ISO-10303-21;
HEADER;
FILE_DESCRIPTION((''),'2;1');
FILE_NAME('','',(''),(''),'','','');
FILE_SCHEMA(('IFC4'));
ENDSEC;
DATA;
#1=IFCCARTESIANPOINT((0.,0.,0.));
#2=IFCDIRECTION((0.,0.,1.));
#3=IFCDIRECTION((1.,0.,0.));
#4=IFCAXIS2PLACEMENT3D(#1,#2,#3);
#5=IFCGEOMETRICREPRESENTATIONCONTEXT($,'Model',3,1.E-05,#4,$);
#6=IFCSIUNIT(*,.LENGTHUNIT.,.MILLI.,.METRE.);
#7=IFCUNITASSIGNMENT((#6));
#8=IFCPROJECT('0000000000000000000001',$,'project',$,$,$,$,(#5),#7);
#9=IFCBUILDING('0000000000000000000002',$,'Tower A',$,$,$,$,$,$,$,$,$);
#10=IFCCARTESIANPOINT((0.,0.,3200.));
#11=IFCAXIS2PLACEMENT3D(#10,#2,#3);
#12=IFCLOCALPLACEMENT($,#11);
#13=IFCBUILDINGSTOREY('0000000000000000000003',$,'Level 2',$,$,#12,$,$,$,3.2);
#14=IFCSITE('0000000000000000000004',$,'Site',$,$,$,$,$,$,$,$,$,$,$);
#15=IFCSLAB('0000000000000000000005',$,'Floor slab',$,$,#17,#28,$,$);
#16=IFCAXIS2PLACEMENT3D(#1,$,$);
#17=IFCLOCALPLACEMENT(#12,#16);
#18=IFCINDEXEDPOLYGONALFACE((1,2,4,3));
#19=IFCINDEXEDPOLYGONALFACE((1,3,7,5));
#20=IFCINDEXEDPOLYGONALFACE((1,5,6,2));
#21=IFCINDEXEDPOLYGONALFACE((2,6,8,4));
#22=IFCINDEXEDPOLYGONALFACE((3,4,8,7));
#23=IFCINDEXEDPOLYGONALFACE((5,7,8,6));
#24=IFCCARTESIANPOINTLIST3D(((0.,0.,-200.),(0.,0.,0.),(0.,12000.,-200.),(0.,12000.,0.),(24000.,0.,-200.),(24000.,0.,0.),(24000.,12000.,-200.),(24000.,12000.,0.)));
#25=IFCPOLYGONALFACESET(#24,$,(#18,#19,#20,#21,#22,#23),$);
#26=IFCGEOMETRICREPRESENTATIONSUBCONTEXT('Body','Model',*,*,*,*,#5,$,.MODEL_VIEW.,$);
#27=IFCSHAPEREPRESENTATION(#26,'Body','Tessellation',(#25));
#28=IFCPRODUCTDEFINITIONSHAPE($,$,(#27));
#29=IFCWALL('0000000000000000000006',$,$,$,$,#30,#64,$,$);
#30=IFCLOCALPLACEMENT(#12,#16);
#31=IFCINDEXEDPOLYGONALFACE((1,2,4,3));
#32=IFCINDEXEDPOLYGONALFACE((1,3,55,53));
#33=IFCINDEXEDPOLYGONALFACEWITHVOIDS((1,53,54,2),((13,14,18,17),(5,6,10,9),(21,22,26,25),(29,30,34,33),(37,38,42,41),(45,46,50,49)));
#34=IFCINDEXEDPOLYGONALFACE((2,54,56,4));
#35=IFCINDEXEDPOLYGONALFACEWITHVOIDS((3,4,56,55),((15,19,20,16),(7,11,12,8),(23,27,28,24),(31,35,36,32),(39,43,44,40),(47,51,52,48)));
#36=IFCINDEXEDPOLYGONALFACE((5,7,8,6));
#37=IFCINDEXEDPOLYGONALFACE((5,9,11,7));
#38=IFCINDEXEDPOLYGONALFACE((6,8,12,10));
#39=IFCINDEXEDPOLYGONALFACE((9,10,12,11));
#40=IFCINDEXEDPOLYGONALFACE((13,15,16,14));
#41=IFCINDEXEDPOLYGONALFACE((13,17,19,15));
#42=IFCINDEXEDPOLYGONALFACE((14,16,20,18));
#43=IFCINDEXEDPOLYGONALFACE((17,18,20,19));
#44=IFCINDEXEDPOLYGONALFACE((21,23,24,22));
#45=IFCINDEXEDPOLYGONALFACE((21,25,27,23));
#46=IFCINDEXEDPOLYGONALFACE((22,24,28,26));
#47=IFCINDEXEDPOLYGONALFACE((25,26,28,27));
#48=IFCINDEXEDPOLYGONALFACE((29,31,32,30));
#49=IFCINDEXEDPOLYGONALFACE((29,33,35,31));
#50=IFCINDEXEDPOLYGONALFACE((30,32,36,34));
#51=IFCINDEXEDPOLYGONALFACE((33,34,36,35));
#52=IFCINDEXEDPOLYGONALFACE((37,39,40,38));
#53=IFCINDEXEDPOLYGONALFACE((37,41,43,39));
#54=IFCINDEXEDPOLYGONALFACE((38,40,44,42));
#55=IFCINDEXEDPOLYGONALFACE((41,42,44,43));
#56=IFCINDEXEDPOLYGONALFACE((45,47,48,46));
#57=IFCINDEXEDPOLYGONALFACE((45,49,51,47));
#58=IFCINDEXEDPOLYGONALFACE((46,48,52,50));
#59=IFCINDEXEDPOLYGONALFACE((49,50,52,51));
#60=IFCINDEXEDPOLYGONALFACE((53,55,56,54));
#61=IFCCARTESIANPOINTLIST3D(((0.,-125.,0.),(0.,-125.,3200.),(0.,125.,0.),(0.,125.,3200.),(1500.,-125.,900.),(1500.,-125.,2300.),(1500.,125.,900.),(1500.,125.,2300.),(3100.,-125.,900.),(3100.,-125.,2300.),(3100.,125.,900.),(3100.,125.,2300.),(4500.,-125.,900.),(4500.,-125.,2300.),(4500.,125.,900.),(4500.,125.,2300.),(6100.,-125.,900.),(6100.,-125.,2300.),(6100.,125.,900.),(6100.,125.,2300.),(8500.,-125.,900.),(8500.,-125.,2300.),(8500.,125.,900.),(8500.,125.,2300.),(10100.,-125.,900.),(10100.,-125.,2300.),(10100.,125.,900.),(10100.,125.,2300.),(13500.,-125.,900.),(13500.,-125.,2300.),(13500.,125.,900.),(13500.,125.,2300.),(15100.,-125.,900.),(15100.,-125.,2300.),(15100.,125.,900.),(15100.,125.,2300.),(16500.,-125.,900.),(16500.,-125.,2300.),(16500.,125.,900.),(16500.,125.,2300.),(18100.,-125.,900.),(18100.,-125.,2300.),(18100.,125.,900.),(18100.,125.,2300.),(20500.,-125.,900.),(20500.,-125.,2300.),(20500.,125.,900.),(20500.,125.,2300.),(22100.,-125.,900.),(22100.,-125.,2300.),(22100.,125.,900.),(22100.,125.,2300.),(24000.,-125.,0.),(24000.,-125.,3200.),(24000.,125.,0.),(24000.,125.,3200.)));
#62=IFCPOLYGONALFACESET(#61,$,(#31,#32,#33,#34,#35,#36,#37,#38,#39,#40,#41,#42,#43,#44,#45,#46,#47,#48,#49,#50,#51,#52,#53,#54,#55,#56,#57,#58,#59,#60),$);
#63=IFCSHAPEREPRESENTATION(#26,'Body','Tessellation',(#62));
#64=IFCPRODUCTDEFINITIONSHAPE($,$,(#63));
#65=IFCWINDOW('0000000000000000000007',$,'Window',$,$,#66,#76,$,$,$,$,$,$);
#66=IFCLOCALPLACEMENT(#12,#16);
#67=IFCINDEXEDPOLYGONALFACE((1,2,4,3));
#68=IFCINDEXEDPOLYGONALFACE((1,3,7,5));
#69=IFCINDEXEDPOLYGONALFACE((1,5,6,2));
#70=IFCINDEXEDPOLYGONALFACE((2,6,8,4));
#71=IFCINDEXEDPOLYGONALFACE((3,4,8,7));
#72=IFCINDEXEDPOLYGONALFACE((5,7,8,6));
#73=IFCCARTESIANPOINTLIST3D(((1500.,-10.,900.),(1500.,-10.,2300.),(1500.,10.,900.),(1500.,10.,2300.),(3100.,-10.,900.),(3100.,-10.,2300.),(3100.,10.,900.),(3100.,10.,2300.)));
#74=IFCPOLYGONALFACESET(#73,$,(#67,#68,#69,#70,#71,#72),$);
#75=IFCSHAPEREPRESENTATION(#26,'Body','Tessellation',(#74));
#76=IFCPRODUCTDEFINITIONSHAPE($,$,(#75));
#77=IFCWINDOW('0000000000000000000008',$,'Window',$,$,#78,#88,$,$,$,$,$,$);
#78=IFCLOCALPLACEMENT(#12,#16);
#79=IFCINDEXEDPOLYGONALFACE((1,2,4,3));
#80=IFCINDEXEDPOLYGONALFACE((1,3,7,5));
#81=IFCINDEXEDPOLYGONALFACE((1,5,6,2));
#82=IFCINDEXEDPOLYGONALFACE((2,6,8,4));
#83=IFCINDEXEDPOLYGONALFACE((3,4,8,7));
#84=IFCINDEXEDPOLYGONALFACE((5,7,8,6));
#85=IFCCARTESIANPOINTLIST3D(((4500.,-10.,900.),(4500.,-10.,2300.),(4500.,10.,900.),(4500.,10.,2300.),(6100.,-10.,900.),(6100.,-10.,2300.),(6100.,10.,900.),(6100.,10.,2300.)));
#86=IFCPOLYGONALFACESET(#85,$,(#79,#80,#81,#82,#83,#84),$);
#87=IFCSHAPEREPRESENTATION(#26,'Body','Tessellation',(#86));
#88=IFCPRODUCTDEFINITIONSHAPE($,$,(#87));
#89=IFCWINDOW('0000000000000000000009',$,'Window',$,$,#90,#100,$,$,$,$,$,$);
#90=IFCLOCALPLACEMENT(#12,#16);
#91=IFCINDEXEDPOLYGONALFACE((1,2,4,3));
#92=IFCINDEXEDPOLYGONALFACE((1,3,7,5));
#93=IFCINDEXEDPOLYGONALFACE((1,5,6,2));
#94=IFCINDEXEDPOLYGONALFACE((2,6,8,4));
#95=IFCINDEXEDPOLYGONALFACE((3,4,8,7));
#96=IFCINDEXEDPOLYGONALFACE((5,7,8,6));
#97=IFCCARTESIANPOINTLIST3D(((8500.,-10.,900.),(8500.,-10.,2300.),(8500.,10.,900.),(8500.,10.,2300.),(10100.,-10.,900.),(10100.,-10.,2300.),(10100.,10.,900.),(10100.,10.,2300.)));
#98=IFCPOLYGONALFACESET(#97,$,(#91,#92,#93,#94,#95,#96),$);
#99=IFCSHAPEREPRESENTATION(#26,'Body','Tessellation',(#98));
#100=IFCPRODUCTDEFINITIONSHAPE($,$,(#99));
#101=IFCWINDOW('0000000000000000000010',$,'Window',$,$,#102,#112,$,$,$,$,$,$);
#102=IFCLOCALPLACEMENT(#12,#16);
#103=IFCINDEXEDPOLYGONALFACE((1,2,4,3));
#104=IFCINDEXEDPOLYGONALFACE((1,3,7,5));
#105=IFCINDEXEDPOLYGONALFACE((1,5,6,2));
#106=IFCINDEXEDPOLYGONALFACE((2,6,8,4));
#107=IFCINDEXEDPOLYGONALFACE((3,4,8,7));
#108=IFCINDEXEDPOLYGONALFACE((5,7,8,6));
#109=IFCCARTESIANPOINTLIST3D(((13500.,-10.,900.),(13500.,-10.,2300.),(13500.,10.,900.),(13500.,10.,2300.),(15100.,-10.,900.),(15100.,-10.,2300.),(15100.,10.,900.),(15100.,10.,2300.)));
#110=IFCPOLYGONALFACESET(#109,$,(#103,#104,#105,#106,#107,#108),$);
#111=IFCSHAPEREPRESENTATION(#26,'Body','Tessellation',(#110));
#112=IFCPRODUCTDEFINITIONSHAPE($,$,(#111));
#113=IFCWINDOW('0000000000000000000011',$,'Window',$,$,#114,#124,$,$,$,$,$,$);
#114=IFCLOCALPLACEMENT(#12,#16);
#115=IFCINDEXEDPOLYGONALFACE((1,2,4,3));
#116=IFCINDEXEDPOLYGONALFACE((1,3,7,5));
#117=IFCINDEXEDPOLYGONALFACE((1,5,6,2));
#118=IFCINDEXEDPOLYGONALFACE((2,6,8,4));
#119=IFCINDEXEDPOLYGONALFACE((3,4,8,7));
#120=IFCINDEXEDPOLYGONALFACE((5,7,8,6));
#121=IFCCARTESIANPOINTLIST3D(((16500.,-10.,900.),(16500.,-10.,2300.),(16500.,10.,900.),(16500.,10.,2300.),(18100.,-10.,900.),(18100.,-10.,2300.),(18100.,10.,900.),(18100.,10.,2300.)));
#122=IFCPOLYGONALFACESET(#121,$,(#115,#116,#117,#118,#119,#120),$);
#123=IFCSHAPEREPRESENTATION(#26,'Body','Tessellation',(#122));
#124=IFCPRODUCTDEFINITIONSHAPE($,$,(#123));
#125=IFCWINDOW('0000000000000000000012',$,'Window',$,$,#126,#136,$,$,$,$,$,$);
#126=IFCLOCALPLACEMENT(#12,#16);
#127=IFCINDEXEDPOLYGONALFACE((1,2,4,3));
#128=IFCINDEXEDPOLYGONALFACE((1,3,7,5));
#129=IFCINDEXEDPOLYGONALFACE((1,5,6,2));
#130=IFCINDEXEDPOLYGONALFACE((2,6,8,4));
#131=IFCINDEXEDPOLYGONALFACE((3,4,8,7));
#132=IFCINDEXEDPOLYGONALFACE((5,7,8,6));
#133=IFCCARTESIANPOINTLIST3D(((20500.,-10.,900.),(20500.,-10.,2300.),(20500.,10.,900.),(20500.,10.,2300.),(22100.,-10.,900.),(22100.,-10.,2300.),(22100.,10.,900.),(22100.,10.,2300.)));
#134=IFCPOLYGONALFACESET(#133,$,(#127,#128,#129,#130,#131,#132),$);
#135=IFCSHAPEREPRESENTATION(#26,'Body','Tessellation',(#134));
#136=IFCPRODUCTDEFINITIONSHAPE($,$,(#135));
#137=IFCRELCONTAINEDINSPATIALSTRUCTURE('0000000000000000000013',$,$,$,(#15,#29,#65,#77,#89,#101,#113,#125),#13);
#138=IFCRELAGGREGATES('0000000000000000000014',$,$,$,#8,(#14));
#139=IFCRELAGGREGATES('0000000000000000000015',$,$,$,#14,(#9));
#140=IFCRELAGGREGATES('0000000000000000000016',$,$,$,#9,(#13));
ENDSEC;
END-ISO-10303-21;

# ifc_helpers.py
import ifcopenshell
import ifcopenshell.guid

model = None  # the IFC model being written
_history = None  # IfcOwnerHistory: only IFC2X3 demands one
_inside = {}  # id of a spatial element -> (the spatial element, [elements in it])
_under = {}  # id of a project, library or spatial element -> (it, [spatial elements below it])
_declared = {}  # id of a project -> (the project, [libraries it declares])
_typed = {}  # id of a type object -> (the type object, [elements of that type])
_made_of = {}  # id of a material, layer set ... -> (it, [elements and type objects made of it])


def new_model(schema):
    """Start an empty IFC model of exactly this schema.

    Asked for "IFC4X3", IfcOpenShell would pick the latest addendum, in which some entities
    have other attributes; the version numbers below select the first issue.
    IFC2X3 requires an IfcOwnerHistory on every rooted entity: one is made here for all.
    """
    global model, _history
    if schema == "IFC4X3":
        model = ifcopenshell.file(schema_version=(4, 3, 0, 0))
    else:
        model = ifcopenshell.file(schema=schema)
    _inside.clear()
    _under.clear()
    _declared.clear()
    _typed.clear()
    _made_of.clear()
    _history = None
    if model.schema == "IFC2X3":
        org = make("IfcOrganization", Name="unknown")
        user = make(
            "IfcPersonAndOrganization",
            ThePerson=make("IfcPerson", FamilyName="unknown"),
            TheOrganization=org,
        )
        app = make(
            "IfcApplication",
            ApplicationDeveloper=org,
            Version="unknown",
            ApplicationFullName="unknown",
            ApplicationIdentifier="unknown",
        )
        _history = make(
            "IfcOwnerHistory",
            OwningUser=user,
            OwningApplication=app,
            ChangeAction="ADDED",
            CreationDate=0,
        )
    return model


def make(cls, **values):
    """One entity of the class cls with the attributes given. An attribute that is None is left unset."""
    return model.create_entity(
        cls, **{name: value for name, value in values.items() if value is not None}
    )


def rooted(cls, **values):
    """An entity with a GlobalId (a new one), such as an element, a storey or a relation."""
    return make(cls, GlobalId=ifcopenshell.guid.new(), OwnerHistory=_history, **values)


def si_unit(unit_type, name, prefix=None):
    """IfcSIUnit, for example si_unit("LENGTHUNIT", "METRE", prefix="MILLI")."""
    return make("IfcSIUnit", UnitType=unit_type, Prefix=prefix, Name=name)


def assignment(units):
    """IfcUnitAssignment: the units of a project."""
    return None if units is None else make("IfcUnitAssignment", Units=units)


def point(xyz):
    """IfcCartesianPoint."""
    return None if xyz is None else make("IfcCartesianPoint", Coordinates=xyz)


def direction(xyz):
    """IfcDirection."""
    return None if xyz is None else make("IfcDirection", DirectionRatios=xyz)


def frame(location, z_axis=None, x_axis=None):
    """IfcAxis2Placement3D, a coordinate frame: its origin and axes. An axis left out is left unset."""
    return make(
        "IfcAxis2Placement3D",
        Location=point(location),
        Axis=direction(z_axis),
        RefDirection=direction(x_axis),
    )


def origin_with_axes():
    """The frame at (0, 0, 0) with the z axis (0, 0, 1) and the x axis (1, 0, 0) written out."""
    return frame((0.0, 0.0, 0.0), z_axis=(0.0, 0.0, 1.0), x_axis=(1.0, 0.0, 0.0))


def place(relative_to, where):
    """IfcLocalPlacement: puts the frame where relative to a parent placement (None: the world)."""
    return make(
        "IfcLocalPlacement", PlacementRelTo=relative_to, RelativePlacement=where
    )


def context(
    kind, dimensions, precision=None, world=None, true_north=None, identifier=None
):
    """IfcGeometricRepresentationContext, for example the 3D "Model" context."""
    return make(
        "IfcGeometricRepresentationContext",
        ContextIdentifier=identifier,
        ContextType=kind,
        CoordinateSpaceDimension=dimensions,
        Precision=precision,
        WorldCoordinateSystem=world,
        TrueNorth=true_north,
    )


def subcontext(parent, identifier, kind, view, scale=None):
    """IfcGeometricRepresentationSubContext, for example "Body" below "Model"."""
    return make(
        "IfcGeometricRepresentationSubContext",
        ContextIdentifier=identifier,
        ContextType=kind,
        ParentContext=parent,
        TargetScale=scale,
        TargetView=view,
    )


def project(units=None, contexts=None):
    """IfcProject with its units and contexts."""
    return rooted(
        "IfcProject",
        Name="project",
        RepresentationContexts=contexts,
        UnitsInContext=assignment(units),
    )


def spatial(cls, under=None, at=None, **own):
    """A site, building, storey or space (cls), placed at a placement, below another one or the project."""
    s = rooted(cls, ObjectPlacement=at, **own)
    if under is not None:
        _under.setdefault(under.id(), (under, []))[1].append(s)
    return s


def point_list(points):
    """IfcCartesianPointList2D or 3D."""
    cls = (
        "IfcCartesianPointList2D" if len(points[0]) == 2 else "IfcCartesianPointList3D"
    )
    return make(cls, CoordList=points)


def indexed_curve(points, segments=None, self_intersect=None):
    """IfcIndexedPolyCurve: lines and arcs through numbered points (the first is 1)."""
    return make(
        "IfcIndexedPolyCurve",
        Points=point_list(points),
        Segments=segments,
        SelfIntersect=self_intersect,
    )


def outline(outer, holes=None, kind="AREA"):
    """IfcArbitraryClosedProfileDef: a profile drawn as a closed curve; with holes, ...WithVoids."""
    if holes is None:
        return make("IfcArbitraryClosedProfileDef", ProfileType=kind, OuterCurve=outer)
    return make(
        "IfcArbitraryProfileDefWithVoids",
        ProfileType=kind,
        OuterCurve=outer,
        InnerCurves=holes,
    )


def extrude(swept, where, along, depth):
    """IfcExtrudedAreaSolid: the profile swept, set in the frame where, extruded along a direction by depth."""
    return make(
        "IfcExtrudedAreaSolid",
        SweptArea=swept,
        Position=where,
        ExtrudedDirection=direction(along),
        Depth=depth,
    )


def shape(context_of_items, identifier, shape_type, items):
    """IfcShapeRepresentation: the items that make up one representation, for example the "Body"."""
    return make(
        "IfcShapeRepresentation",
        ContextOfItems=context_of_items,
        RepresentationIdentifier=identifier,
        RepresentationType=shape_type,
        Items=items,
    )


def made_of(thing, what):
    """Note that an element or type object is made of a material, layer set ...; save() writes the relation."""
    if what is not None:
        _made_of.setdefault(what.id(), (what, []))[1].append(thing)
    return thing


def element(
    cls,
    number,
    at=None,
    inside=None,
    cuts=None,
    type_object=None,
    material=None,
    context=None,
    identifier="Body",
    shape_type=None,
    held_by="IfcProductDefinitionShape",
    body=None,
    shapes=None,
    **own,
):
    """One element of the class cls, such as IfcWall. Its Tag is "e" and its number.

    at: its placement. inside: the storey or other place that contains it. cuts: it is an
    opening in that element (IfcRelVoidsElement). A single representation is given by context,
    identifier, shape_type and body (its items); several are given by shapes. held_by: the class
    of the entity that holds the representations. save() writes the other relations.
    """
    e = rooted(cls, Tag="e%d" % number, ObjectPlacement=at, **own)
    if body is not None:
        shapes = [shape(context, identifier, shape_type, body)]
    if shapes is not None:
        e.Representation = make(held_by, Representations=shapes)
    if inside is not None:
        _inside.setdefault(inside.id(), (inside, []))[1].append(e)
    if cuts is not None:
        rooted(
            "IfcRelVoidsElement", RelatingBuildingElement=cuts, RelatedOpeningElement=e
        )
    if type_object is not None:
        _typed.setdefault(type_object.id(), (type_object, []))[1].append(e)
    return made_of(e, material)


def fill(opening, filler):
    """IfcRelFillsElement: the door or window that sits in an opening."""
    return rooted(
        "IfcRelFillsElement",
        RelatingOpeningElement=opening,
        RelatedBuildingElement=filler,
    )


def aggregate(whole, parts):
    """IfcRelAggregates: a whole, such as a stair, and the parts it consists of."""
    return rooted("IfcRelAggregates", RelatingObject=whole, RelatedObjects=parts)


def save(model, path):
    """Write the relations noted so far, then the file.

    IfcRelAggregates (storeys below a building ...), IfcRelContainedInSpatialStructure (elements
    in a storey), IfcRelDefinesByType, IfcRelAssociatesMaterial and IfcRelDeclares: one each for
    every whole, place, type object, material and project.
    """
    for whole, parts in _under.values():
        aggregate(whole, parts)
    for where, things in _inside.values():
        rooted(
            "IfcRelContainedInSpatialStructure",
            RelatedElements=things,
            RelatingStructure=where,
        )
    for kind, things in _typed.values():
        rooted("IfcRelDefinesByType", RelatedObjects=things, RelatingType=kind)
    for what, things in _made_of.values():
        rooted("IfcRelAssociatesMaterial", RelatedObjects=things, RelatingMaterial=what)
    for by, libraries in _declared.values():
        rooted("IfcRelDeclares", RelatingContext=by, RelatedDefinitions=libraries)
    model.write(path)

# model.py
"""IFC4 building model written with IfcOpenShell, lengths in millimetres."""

from ifc_helpers import new_model, si_unit, frame, origin_with_axes, place, context, subcontext, project, spatial, indexed_curve, outline, extrude, element, fill, save


model = new_model("IFC4")

# Units and contexts
model_context = context("Model", 3, precision=1e-05, world=origin_with_axes())
body_context = subcontext(model_context, "Body", "Model", "MODEL_VIEW")
ifc_project = project(units=[si_unit("LENGTHUNIT", "METRE", prefix="MILLI")], contexts=[model_context])

# Site, building, storey
site = spatial("IfcSite", under=ifc_project, Name="Site")
building = spatial("IfcBuilding", under=site, Name="Tower A")
storey_placement = place(None, frame((0.0, 0.0, 3200.0), z_axis=(0.0, 0.0, 1.0), x_axis=(1.0, 0.0, 0.0)))
storey = spatial("IfcBuildingStorey", under=building, at=storey_placement, Name="Level 2", Elevation=3.2)

# Slab
slab_placement = place(storey_placement, frame((0.0, 0.0, -200.0), z_axis=(0.0, 0.0, 1.0), x_axis=(1.0, 0.0, 0.0)))
element("IfcSlab", 1, at=slab_placement, inside=storey, Name="Floor slab", context=body_context, shape_type="SweptSolid", body=[
    extrude(outline(indexed_curve([(0.0, 0.0), (24000.0, 0.0), (24000.0, 12000.0), (0.0, 12000.0)])), None, (0.0, 0.0, 1.0), 200.0),
])

# Wall, openings, windows
wall_1_placement = place(storey_placement, frame((0.0, -125.0, 0.0), z_axis=(0.0, 0.0, 1.0), x_axis=(1.0, 0.0, 0.0)))
wall_1 = element("IfcWall", 2, at=wall_1_placement, inside=storey, context=body_context, shape_type="SweptSolid", body=[
    extrude(outline(indexed_curve([(0.0, 0.0), (0.0, 250.0), (24000.0, 250.0), (24000.0, 0.0), (0.0, 0.0)], self_intersect=False)), origin_with_axes(), (0.0, 0.0, 1.0), 3200.0),
])
opening_1_placement = place(wall_1_placement, frame((1500.0, 0.0, 900.0), z_axis=(0.0, 0.0, 1.0), x_axis=(1.0, 0.0, 0.0)))
opening_1 = element("IfcOpeningElement", 3, at=opening_1_placement, cuts=wall_1, context=body_context, shape_type="SweptSolid", body=[
    extrude(outline(indexed_curve([(0.0, 0.0), (0.0, 250.0), (1600.0, 250.0), (1600.0, 0.0), (0.0, 0.0)], self_intersect=False)), origin_with_axes(), (0.0, 0.0, 1.0), 1400.0),
])
opening_2_placement = place(wall_1_placement, frame((4500.0, 0.0, 900.0), z_axis=(0.0, 0.0, 1.0), x_axis=(1.0, 0.0, 0.0)))
opening_2 = element("IfcOpeningElement", 4, at=opening_2_placement, cuts=wall_1, context=body_context, shape_type="SweptSolid", body=[
    extrude(outline(indexed_curve([(0.0, 0.0), (0.0, 250.0), (1600.0, 250.0), (1600.0, 0.0), (0.0, 0.0)], self_intersect=False)), origin_with_axes(), (0.0, 0.0, 1.0), 1400.0),
])
opening_3_placement = place(wall_1_placement, frame((8500.0, 0.0, 900.0), z_axis=(0.0, 0.0, 1.0), x_axis=(1.0, 0.0, 0.0)))
opening_3 = element("IfcOpeningElement", 5, at=opening_3_placement, cuts=wall_1, context=body_context, shape_type="SweptSolid", body=[
    extrude(outline(indexed_curve([(0.0, 0.0), (0.0, 250.0), (1600.0, 250.0), (1600.0, 0.0), (0.0, 0.0)], self_intersect=False)), origin_with_axes(), (0.0, 0.0, 1.0), 1400.0),
])
opening_4_placement = place(wall_1_placement, frame((13500.0, 0.0, 900.0), z_axis=(0.0, 0.0, 1.0), x_axis=(1.0, 0.0, 0.0)))
opening_4 = element("IfcOpeningElement", 6, at=opening_4_placement, cuts=wall_1, context=body_context, shape_type="SweptSolid", body=[
    extrude(outline(indexed_curve([(0.0, 0.0), (0.0, 250.0), (1600.0, 250.0), (1600.0, 0.0), (0.0, 0.0)], self_intersect=False)), origin_with_axes(), (0.0, 0.0, 1.0), 1400.0),
])
opening_5_placement = place(wall_1_placement, frame((16500.0, 0.0, 900.0), z_axis=(0.0, 0.0, 1.0), x_axis=(1.0, 0.0, 0.0)))
opening_5 = element("IfcOpeningElement", 7, at=opening_5_placement, cuts=wall_1, context=body_context, shape_type="SweptSolid", body=[
    extrude(outline(indexed_curve([(0.0, 0.0), (0.0, 250.0), (1600.0, 250.0), (1600.0, 0.0), (0.0, 0.0)], self_intersect=False)), origin_with_axes(), (0.0, 0.0, 1.0), 1400.0),
])
opening_6_placement = place(wall_1_placement, frame((20500.0, 0.0, 900.0), z_axis=(0.0, 0.0, 1.0), x_axis=(1.0, 0.0, 0.0)))
opening_6 = element("IfcOpeningElement", 8, at=opening_6_placement, cuts=wall_1, context=body_context, shape_type="SweptSolid", body=[
    extrude(outline(indexed_curve([(0.0, 0.0), (0.0, 250.0), (1600.0, 250.0), (1600.0, 0.0), (0.0, 0.0)], self_intersect=False)), origin_with_axes(), (0.0, 0.0, 1.0), 1400.0),
])
window_1_placement = place(storey_placement, frame((1500.0, -10.0, 900.0), z_axis=(0.0, 0.0, 1.0), x_axis=(1.0, 0.0, 0.0)))
window_1 = element("IfcWindow", 9, at=window_1_placement, inside=storey, Name="Window", context=body_context, shape_type="SweptSolid", body=[
    extrude(outline(indexed_curve([(0.0, 0.0), (0.0, 20.0), (1600.0, 20.0), (1600.0, 0.0), (0.0, 0.0)], self_intersect=False)), origin_with_axes(), (0.0, 0.0, 1.0), 1400.0),
])
fill(opening_1, window_1)
window_2_placement = place(storey_placement, frame((4500.0, -10.0, 900.0), z_axis=(0.0, 0.0, 1.0), x_axis=(1.0, 0.0, 0.0)))
window_2 = element("IfcWindow", 10, at=window_2_placement, inside=storey, Name="Window", context=body_context, shape_type="SweptSolid", body=[
    extrude(outline(indexed_curve([(0.0, 0.0), (0.0, 20.0), (1600.0, 20.0), (1600.0, 0.0), (0.0, 0.0)], self_intersect=False)), origin_with_axes(), (0.0, 0.0, 1.0), 1400.0),
])
fill(opening_2, window_2)
window_3_placement = place(storey_placement, frame((8500.0, -10.0, 900.0), z_axis=(0.0, 0.0, 1.0), x_axis=(1.0, 0.0, 0.0)))
window_3 = element("IfcWindow", 11, at=window_3_placement, inside=storey, Name="Window", context=body_context, shape_type="SweptSolid", body=[
    extrude(outline(indexed_curve([(0.0, 0.0), (0.0, 20.0), (1600.0, 20.0), (1600.0, 0.0), (0.0, 0.0)], self_intersect=False)), origin_with_axes(), (0.0, 0.0, 1.0), 1400.0),
])
fill(opening_3, window_3)
window_4_placement = place(storey_placement, frame((13500.0, -10.0, 900.0), z_axis=(0.0, 0.0, 1.0), x_axis=(1.0, 0.0, 0.0)))
window_4 = element("IfcWindow", 12, at=window_4_placement, inside=storey, Name="Window", context=body_context, shape_type="SweptSolid", body=[
    extrude(outline(indexed_curve([(0.0, 0.0), (0.0, 20.0), (1600.0, 20.0), (1600.0, 0.0), (0.0, 0.0)], self_intersect=False)), origin_with_axes(), (0.0, 0.0, 1.0), 1400.0),
])
fill(opening_4, window_4)
window_5_placement = place(storey_placement, frame((16500.0, -10.0, 900.0), z_axis=(0.0, 0.0, 1.0), x_axis=(1.0, 0.0, 0.0)))
window_5 = element("IfcWindow", 13, at=window_5_placement, inside=storey, Name="Window", context=body_context, shape_type="SweptSolid", body=[
    extrude(outline(indexed_curve([(0.0, 0.0), (0.0, 20.0), (1600.0, 20.0), (1600.0, 0.0), (0.0, 0.0)], self_intersect=False)), origin_with_axes(), (0.0, 0.0, 1.0), 1400.0),
])
fill(opening_5, window_5)
window_6_placement = place(storey_placement, frame((20500.0, -10.0, 900.0), z_axis=(0.0, 0.0, 1.0), x_axis=(1.0, 0.0, 0.0)))
window_6 = element("IfcWindow", 14, at=window_6_placement, inside=storey, Name="Window", context=body_context, shape_type="SweptSolid", body=[
    extrude(outline(indexed_curve([(0.0, 0.0), (0.0, 20.0), (1600.0, 20.0), (1600.0, 0.0), (0.0, 0.0)], self_intersect=False)), origin_with_axes(), (0.0, 0.0, 1.0), 1400.0),
])
fill(opening_6, window_6)

save(model, "model.ifc")
